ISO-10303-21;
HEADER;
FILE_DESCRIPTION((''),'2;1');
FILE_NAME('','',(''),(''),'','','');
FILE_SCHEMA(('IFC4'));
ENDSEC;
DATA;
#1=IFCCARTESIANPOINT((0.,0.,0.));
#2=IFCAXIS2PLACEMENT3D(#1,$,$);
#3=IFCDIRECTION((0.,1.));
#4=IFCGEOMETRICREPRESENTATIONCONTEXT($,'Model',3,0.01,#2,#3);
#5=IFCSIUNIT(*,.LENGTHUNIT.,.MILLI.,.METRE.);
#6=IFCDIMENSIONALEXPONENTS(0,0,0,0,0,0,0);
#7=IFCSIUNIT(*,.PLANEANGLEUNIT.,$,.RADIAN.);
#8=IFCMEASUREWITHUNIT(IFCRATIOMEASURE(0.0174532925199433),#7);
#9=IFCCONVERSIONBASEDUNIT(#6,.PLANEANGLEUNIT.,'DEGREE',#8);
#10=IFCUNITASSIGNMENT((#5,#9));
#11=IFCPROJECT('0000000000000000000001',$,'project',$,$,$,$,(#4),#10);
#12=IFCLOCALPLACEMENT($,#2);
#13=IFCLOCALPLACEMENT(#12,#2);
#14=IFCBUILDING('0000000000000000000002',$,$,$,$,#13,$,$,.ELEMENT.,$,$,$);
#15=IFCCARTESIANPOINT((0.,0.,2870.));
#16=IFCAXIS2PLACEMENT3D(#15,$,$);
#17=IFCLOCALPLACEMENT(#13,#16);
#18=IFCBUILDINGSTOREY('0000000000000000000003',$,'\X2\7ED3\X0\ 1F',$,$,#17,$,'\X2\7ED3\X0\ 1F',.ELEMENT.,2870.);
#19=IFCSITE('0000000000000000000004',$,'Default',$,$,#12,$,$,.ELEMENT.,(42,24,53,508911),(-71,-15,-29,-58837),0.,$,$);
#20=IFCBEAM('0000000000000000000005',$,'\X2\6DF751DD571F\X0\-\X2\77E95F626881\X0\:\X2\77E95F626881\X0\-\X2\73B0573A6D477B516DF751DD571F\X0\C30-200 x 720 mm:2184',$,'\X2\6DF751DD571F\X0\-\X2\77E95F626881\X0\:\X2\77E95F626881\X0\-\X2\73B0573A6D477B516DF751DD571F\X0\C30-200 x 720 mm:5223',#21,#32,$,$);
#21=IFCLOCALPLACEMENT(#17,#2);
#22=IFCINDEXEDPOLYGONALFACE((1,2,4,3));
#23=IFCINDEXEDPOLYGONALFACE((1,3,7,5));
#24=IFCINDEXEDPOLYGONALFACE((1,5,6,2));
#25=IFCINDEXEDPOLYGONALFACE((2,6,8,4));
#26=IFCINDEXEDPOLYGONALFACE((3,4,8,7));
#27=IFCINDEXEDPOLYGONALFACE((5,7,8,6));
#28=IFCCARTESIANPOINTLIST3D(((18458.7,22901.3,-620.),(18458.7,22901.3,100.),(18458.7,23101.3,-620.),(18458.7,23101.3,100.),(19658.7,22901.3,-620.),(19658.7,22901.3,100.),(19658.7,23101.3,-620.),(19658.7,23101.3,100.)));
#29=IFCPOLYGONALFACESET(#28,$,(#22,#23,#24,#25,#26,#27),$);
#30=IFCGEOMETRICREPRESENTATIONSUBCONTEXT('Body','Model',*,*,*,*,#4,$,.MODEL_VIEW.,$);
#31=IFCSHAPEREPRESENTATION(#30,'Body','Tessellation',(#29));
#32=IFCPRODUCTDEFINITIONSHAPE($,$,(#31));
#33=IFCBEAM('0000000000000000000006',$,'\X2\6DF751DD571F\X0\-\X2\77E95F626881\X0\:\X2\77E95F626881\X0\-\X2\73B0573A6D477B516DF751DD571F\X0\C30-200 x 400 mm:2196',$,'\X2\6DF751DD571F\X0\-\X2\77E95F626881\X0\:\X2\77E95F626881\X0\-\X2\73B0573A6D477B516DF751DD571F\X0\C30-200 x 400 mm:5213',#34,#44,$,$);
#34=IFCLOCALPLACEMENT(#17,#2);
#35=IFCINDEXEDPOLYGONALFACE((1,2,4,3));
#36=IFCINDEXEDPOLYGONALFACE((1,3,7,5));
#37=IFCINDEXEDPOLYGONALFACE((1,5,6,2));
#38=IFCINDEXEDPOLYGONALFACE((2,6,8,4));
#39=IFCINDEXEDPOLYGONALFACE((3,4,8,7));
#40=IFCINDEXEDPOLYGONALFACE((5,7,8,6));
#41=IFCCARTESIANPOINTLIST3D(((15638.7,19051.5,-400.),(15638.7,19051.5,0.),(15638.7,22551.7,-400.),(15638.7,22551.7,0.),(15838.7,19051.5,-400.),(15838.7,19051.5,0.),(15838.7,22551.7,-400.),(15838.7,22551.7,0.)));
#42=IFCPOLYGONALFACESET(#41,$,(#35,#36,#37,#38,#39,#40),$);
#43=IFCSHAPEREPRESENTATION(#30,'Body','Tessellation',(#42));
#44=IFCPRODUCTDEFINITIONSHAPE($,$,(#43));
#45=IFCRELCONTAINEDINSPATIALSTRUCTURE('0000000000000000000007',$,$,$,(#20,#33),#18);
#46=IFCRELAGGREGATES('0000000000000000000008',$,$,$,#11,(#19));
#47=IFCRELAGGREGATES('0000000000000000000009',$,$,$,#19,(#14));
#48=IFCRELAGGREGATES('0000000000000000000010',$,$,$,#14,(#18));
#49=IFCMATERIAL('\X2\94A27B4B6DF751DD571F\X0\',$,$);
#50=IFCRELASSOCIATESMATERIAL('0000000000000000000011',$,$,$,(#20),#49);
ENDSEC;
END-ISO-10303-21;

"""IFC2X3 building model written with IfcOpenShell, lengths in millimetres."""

from ifc_helpers import new_model, entity, si_unit, converted_unit, direction, frame, frame_2d, origin, place, context, subcontext, project, spatial, rectangle, extrude, material, element, save


model = new_model("IFC2X3")

# Units and contexts
model_context = context("Model", 3, precision=0.01, world=origin(), true_north=direction((0.0, 1.0)))
body_context = subcontext(model_context, "Body", "Model", "MODEL_VIEW")
ifc_project = project(units=[si_unit("LENGTHUNIT", "METRE", prefix="MILLI"), converted_unit("PLANEANGLEUNIT", "DEGREE", entity("IfcRatioMeasure", 0.0174532925199433), si_unit("PLANEANGLEUNIT", "RADIAN"), dimensions=[0, 0, 0, 0, 0, 0, 0])], contexts=[model_context])

# Site, building, storey
site_placement = place(None, origin())
site = spatial("IfcSite", under=ifc_project, at=site_placement, Name="Default", CompositionType="ELEMENT", RefLatitude=(42, 24, 53, 508911), RefLongitude=(-71, -15, -29, -58837), RefElevation=0.0)
building_placement = place(site_placement, origin())
building = spatial("IfcBuilding", under=site, at=building_placement, CompositionType="ELEMENT")
storey_placement = place(building_placement, frame((0.0, 0.0, 2870.0)))
storey = spatial("IfcBuildingStorey", under=building, at=storey_placement, Name="结 1F", LongName="结 1F", CompositionType="ELEMENT", Elevation=2870.0)

# Beams
ifc_material = material(Name="钢筋混凝土")
beam_1_placement = place(storey_placement, frame((17708.7, 23001.3, 100.0)))
element("IfcBeam", 1, at=beam_1_placement, inside=storey, material=ifc_material, Name="混凝土-矩形梁:矩形梁-现场浇筑混凝土C30-200 x 720 mm:2184", ObjectType="混凝土-矩形梁:矩形梁-现场浇筑混凝土C30-200 x 720 mm:5223", context=body_context, shape_type="SweptSolid", body=[
    extrude(rectangle(XDim=720.0, YDim=200.0, at=frame_2d((0.0, 0.0), x_axis=(1.0, 0.0))), frame((750.0, 0.0, -360.0), z_axis=(1.0, 0.0, 0.0), x_axis=(0.0, 0.0, -1.0)), (0.0, 0.0, 1.0), 1200.0),
])
beam_2_placement = place(storey_placement, frame((15738.7, 18951.5, 0.0), z_axis=(0.0, 0.0, 1.0), x_axis=(0.0, 1.0, 0.0)))
element("IfcBeam", 2, at=beam_2_placement, inside=storey, Name="混凝土-矩形梁:矩形梁-现场浇筑混凝土C30-200 x 400 mm:2196", ObjectType="混凝土-矩形梁:矩形梁-现场浇筑混凝土C30-200 x 400 mm:5213", context=body_context, shape_type="SweptSolid", body=[
    extrude(rectangle(XDim=400.0, YDim=200.0, at=frame_2d((0.0, 0.0), x_axis=(1.0, 0.0))), frame((100.0, 0.0, -200.0), z_axis=(1.0, 0.0, 0.0), x_axis=(0.0, 0.0, -1.0)), (0.0, 0.0, 1.0), 3500.3),
])

save(model, "model.ifc")
